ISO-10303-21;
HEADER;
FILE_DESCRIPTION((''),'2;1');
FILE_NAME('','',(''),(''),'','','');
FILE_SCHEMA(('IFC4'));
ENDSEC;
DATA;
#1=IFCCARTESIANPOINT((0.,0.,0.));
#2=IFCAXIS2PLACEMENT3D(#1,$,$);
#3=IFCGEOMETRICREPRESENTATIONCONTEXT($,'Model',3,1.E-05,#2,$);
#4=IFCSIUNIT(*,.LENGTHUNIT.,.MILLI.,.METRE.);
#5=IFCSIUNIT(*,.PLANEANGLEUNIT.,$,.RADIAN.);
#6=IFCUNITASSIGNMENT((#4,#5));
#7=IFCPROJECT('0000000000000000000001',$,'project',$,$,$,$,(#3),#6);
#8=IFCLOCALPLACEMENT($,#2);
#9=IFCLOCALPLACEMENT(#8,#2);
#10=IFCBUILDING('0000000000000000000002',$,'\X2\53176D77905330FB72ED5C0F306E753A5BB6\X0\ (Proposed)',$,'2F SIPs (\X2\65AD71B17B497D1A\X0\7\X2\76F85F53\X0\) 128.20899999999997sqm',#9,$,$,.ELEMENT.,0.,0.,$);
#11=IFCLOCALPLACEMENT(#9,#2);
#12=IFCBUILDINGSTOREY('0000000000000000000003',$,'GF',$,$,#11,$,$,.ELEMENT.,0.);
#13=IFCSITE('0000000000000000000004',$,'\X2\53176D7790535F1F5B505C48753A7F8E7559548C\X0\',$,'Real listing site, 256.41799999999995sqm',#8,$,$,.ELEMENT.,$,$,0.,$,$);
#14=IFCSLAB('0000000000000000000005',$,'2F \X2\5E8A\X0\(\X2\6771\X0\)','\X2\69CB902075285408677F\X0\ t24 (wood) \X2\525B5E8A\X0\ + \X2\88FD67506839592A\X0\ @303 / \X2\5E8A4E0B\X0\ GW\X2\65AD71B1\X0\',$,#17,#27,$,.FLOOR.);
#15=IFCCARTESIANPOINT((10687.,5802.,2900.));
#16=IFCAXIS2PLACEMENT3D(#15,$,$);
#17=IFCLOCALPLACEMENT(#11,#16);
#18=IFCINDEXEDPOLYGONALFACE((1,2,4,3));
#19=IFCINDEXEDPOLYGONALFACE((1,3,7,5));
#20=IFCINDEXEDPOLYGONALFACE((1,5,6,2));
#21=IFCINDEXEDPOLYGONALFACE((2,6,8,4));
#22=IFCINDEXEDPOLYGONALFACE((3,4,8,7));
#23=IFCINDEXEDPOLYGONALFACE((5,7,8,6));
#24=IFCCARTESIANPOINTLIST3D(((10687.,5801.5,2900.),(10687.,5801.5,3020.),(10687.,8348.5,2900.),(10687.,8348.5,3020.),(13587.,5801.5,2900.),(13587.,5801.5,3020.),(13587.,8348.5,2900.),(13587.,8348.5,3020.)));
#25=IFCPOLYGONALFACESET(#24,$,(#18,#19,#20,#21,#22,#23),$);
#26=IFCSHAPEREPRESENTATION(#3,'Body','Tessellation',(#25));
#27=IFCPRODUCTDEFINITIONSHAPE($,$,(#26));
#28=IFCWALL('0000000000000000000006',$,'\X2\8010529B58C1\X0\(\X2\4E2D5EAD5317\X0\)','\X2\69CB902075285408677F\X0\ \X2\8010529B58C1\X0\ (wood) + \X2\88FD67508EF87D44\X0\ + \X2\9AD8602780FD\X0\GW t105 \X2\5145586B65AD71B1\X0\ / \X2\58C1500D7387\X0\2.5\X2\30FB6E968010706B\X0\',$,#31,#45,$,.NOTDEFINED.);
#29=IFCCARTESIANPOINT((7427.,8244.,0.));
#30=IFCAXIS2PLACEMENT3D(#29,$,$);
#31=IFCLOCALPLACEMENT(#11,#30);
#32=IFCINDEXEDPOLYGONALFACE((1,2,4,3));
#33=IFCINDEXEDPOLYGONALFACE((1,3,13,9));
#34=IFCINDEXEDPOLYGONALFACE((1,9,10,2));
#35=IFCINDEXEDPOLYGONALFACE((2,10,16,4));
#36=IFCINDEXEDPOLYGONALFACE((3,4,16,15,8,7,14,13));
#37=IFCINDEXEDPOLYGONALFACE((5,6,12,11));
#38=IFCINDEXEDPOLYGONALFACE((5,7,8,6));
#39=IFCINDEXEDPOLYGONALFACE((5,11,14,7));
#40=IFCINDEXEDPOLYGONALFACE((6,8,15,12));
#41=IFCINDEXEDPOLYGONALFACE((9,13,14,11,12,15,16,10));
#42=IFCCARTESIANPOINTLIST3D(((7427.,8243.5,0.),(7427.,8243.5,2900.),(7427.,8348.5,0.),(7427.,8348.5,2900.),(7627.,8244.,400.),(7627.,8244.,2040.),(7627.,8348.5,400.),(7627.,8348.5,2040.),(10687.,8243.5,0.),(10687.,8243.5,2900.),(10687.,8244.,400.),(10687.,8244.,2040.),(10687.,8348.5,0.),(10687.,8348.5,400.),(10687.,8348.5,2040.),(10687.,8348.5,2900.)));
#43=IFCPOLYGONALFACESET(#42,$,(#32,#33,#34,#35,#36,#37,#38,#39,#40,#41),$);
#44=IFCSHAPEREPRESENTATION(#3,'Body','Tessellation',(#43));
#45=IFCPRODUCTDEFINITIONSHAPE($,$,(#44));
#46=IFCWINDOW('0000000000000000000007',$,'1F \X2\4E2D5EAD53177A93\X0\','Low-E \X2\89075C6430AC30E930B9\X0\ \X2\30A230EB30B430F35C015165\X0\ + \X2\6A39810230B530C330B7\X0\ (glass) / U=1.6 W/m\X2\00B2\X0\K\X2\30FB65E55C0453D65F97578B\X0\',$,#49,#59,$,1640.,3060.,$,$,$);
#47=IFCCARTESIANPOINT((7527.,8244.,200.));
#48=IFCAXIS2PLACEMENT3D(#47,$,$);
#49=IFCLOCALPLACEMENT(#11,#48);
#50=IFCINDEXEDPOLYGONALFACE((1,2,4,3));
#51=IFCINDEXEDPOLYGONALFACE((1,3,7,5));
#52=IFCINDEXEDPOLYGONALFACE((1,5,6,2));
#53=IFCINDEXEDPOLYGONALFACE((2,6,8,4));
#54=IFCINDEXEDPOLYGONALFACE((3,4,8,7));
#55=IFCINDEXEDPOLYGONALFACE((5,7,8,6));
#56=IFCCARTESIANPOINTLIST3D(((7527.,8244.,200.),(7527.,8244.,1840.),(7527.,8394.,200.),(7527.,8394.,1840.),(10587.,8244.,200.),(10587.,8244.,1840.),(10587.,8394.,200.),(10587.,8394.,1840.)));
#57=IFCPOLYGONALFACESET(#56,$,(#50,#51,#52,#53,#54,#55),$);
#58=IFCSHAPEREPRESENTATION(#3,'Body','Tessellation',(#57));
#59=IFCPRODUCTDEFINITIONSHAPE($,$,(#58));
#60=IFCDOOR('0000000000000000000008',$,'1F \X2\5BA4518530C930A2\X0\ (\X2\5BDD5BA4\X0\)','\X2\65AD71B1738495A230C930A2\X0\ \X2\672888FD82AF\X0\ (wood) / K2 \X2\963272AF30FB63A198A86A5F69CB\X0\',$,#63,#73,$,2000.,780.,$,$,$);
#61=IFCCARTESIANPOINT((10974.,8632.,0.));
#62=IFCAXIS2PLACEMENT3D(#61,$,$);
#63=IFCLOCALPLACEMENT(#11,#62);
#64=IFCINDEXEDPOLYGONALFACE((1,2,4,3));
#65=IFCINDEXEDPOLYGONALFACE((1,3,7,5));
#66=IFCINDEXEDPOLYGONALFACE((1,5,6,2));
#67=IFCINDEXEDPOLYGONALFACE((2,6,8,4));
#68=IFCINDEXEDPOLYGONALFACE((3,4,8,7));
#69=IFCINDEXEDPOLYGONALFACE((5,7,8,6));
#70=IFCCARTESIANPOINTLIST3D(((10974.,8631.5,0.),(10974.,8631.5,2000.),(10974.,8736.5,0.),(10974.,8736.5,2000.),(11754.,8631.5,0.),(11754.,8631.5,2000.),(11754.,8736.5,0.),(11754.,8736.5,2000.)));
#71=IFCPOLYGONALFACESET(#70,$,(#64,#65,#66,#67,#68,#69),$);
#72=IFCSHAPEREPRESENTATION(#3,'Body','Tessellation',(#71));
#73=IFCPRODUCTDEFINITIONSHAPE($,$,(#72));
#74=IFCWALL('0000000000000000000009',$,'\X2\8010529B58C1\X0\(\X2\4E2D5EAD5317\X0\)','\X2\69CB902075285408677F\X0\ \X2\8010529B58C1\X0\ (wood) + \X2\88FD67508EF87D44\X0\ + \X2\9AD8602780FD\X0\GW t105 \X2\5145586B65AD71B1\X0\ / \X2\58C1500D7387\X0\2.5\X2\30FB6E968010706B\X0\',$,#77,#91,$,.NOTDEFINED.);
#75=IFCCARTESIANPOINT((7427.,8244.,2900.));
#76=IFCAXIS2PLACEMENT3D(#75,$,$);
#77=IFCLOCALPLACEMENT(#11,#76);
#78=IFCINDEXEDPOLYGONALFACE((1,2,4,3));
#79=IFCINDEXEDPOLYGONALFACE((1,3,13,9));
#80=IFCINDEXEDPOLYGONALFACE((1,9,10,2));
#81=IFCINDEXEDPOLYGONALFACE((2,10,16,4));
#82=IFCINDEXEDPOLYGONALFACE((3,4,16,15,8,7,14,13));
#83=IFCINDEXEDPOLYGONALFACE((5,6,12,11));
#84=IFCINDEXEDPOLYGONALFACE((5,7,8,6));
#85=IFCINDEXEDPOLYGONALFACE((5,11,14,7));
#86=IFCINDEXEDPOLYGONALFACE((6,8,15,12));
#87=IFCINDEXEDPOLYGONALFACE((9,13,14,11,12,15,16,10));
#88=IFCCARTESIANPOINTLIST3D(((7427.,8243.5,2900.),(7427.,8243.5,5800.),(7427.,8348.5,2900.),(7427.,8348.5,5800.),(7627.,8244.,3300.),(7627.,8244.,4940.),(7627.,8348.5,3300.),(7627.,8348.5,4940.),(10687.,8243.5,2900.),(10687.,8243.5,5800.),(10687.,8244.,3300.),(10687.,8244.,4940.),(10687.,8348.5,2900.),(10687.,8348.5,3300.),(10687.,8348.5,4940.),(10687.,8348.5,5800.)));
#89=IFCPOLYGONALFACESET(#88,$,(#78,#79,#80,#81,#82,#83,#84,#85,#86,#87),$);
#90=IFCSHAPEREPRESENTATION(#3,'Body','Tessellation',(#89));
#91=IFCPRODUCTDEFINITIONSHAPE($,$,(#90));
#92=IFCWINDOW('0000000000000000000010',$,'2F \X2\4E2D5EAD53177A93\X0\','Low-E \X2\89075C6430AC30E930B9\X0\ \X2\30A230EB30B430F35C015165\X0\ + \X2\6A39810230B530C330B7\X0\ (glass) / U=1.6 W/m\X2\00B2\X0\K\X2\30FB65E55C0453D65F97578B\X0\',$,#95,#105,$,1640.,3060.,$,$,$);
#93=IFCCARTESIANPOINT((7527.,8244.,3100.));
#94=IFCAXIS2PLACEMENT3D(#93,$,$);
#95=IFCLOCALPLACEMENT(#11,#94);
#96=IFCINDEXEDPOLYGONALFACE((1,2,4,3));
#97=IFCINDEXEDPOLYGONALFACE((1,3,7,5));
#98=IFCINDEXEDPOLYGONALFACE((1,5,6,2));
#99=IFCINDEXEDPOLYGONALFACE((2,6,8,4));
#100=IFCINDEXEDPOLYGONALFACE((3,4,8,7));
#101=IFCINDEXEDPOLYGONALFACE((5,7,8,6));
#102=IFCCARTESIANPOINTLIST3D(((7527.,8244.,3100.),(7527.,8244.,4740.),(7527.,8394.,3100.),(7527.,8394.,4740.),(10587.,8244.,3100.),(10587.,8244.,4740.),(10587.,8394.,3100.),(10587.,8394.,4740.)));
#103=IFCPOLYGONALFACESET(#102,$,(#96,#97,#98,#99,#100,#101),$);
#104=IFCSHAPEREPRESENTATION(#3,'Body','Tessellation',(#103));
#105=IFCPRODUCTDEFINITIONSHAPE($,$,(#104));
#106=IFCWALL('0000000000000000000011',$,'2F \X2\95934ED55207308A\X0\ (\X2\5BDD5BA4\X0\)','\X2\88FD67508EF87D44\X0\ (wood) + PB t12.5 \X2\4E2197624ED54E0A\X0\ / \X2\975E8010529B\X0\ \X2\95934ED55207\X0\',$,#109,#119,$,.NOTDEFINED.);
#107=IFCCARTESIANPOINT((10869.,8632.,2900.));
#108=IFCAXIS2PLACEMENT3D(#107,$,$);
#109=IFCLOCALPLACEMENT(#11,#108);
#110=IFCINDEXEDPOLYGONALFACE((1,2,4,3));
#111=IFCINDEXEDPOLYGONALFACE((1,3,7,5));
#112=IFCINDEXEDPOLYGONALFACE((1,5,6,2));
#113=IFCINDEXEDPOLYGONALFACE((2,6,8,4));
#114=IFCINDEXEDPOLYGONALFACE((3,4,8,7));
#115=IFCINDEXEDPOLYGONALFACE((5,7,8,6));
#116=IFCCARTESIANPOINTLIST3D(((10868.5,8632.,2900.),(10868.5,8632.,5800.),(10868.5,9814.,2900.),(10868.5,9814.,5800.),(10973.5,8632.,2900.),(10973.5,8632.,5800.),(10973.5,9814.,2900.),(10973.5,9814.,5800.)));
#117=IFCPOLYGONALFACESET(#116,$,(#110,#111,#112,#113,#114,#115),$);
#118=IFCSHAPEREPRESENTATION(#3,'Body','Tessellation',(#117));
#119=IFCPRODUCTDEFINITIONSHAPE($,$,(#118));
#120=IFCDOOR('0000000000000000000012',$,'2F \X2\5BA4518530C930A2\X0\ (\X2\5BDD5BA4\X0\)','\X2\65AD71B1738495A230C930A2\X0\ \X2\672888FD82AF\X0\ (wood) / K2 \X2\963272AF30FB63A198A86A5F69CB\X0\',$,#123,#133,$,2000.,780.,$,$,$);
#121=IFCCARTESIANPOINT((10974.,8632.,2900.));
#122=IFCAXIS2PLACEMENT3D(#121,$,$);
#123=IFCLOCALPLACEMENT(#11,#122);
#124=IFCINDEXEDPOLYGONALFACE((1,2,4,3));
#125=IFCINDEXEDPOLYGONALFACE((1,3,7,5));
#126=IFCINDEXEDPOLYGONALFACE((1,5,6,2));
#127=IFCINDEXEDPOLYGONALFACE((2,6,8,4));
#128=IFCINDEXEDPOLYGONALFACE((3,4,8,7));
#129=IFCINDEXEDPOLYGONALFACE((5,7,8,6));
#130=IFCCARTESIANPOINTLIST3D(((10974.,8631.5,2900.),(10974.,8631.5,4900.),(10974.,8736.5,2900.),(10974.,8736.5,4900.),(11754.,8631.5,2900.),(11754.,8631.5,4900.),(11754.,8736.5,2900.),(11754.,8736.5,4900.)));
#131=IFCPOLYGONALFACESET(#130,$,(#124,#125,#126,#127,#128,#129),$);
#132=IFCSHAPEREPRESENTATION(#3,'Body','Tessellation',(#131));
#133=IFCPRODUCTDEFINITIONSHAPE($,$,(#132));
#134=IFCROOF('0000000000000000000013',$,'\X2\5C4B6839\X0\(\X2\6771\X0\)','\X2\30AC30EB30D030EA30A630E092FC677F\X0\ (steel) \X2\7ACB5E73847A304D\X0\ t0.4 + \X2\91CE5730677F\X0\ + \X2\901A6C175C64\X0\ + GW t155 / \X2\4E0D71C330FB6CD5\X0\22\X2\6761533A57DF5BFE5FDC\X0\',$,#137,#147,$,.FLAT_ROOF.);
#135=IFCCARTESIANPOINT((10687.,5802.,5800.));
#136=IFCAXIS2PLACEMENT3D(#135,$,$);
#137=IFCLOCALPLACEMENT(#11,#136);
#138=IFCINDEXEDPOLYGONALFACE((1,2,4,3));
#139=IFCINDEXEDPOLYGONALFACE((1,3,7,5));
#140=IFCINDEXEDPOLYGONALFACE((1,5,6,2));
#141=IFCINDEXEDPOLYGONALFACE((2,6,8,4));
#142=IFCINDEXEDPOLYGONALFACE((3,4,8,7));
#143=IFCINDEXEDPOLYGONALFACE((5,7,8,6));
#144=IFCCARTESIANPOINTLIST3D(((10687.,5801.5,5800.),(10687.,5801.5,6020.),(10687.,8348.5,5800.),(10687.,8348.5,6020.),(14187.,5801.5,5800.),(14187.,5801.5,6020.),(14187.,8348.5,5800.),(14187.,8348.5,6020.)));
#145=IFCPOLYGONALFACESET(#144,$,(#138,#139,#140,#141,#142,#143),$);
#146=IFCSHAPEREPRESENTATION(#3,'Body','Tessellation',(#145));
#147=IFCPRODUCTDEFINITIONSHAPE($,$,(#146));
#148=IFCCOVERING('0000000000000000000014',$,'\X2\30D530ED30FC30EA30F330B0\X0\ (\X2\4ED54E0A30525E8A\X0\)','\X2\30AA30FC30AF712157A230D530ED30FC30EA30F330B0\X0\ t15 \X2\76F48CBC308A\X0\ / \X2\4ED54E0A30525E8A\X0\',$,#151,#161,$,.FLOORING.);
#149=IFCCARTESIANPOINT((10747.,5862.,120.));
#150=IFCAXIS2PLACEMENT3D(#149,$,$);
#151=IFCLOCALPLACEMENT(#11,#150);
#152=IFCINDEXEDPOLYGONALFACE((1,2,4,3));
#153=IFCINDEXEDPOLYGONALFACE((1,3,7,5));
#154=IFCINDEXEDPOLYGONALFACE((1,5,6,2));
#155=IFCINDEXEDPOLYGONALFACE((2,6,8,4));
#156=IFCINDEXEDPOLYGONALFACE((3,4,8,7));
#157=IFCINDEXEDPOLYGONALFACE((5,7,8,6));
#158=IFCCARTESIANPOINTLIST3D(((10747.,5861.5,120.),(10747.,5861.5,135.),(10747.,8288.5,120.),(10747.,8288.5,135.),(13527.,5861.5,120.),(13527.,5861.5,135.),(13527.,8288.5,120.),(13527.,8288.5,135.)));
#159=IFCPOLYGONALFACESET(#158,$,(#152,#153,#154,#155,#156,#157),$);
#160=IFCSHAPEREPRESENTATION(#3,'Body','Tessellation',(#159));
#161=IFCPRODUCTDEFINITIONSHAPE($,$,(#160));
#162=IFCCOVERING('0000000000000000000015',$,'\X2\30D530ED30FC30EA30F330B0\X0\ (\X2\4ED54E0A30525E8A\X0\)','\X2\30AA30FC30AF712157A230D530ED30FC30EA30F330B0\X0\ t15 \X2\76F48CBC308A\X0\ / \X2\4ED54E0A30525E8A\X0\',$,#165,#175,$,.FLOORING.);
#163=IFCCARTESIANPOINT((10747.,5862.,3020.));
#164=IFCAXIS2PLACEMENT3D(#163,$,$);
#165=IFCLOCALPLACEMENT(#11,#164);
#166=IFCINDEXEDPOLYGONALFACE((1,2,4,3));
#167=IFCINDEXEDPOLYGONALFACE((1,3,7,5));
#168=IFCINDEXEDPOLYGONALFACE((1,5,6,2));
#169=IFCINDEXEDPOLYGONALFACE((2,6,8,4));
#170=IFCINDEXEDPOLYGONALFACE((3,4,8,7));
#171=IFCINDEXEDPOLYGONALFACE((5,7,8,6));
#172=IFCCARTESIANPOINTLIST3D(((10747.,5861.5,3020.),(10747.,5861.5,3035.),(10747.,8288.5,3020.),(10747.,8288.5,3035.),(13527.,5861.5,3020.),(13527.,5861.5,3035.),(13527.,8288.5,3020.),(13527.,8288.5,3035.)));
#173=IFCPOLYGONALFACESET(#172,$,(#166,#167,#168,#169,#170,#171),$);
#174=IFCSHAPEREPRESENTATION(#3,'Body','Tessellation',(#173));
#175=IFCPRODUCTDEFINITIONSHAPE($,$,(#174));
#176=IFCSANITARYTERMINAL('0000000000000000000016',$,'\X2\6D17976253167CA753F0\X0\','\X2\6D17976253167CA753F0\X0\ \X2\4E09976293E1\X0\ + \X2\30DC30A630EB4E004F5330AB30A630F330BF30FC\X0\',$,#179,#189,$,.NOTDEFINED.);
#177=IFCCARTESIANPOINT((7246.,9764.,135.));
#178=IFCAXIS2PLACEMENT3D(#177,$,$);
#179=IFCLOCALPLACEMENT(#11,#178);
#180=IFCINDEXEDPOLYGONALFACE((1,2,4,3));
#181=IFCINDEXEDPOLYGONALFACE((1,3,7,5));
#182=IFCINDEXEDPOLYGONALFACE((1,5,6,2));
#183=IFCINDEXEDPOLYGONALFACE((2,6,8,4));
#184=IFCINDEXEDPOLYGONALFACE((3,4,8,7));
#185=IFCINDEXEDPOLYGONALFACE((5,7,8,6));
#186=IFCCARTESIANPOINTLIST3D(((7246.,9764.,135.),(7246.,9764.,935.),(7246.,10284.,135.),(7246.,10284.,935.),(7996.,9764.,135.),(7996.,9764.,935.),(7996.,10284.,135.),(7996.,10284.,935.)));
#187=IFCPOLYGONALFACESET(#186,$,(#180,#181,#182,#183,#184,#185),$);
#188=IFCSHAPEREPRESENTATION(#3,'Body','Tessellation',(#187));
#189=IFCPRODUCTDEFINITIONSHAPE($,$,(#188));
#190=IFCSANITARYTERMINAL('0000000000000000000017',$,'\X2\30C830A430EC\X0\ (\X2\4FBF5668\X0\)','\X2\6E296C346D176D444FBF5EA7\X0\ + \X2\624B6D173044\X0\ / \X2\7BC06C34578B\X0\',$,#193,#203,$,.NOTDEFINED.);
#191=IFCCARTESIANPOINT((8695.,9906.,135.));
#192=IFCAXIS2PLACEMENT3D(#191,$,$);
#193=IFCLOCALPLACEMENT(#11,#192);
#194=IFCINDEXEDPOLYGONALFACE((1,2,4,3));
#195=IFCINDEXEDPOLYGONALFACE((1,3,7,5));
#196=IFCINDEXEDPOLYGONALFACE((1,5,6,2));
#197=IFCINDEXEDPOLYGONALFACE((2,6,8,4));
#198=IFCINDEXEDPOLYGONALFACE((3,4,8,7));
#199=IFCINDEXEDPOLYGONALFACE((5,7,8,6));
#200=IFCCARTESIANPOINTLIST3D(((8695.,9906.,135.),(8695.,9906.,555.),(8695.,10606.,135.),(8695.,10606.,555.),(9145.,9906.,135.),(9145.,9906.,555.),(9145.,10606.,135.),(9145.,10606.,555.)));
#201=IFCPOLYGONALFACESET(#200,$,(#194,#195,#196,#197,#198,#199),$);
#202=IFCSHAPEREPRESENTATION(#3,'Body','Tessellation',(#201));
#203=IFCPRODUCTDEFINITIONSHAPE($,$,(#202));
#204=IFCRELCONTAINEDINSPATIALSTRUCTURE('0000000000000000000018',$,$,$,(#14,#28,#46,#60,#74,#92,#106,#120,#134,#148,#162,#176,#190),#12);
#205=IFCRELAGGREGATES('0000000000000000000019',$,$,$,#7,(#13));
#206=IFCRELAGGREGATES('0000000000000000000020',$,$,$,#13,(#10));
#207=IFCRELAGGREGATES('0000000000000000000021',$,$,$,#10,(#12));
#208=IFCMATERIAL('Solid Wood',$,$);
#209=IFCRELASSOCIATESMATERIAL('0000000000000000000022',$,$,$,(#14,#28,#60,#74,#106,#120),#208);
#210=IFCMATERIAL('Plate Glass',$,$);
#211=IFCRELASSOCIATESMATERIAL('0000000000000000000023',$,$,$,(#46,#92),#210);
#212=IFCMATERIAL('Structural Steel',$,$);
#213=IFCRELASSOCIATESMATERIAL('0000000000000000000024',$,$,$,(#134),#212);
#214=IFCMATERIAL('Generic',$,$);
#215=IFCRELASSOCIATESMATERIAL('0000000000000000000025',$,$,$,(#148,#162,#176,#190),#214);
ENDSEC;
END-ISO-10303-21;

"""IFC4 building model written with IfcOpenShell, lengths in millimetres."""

from ifc_helpers import new_model, si_unit, frame, frame_2d, origin, place, context, project, spatial, rectangle, extrude, material, element, fill, save


model = new_model("IFC4")

# Units and contexts
model_context = context("Model", 3, precision=1e-05, world=origin())
ifc_project = project(units=[si_unit("LENGTHUNIT", "METRE", prefix="MILLI"), si_unit("PLANEANGLEUNIT", "RADIAN")], contexts=[model_context])

# Site, building, storey
site_placement = place(None, origin())
site = spatial("IfcSite", under=ifc_project, at=site_placement, Name="北海道弟子屈町美留和", ObjectType="Real listing site, 256.41799999999995sqm", CompositionType="ELEMENT", RefElevation=0.0)
building_placement = place(site_placement, origin())
building = spatial("IfcBuilding", under=site, at=building_placement, Name="北海道・狭小の町家 (Proposed)", ObjectType="2F SIPs (断熱等級7相当) 128.20899999999997sqm", CompositionType="ELEMENT", ElevationOfRefHeight=0.0, ElevationOfTerrain=0.0)
storey_placement = place(building_placement, origin())
storey = spatial("IfcBuildingStorey", under=building, at=storey_placement, Name="GF", CompositionType="ELEMENT", Elevation=0.0)

# Slab
ifc_material_1 = material(Name="Solid Wood")
slab_1_placement = place(storey_placement, frame((10687.0, 5802.0, 2900.0)))
element("IfcSlab", 1, at=slab_1_placement, inside=storey, material=ifc_material_1, Name="2F 床(東)", Description="構造用合板 t24 (wood) 剛床 + 製材根太 @303 / 床下 GW断熱", PredefinedType="FLOOR", context=model_context, shape_type="SweptSolid", body=[
    extrude(rectangle(XDim=2900.0, YDim=2547.0, at=frame_2d((1450.0, 1273.0))), frame((10687.0, 5802.0, 2900.0)), (0.0, 0.0, 1.0), 120.0),
])

# Wall, opening, window
wall_1_placement = place(storey_placement, frame((7427.0, 8244.0, 0.0)))
wall_1 = element("IfcWall", 2, at=wall_1_placement, inside=storey, material=ifc_material_1, Name="耐力壁(中庭北)", Description="構造用合板 耐力壁 (wood) + 製材軸組 + 高性能GW t105 充填断熱 / 壁倍率2.5・準耐火", PredefinedType="NOTDEFINED", context=model_context, shape_type="SweptSolid", body=[
    extrude(rectangle(XDim=3260.0, YDim=105.0, at=frame_2d((1630.0, 52.0))), frame((7427.0, 8244.0, 0.0)), (0.0, 0.0, 1.0), 2900.0),
])
opening_1_placement = place(storey_placement, frame((7527.0, 8244.0, 200.0)))
opening_1 = element("IfcOpeningElement", 3, at=opening_1_placement, cuts=wall_1, PredefinedType="NOTDEFINED", context=model_context, shape_type="SweptSolid", body=[
    extrude(rectangle(XDim=3060.0, YDim=150.0, at=frame_2d((1530.0, 75.0))), frame((7527.0, 8244.0, 200.0)), (0.0, 0.0, 1.0), 1640.0),
])
ifc_material_2 = material(Name="Plate Glass")
window_1_placement = place(storey_placement, frame((7527.0, 8244.0, 200.0)))
window_1 = element("IfcWindow", 4, at=window_1_placement, inside=storey, material=ifc_material_2, Name="1F 中庭北窓", Description="Low-E 複層ガラス アルゴン封入 + 樹脂サッシ (glass) / U=1.6 W/m²K・日射取得型", OverallHeight=1640.0, OverallWidth=3060.0, context=model_context, shape_type="SweptSolid", body=[
    extrude(rectangle(XDim=3060.0, YDim=150.0, at=frame_2d((1530.0, 75.0))), frame((7527.0, 8244.0, 200.0)), (0.0, 0.0, 1.0), 1640.0),
])
fill(opening_1, window_1)

# Door
door_1_placement = place(storey_placement, frame((10974.0, 8632.0, 0.0)))
element("IfcDoor", 5, at=door_1_placement, inside=storey, material=ifc_material_1, Name="1F 室内ドア (寝室)", Description="断熱玄関ドア 木製芯 (wood) / K2 防犯・採風機構", OverallHeight=2000.0, OverallWidth=780.0, context=model_context, shape_type="SweptSolid", body=[
    extrude(rectangle(XDim=780.0, YDim=105.0, at=frame_2d((390.0, 52.0))), frame((10974.0, 8632.0, 0.0)), (0.0, 0.0, 1.0), 2000.0),
])

# Wall, opening, window
wall_2_placement = place(storey_placement, frame((7427.0, 8244.0, 2900.0)))
wall_2 = element("IfcWall", 6, at=wall_2_placement, inside=storey, material=ifc_material_1, Name="耐力壁(中庭北)", Description="構造用合板 耐力壁 (wood) + 製材軸組 + 高性能GW t105 充填断熱 / 壁倍率2.5・準耐火", PredefinedType="NOTDEFINED", context=model_context, shape_type="SweptSolid", body=[
    extrude(rectangle(XDim=3260.0, YDim=105.0, at=frame_2d((1630.0, 52.0))), frame((7427.0, 8244.0, 2900.0)), (0.0, 0.0, 1.0), 2900.0),
])
opening_2_placement = place(storey_placement, frame((7527.0, 8244.0, 3100.0)))
opening_2 = element("IfcOpeningElement", 7, at=opening_2_placement, cuts=wall_2, PredefinedType="NOTDEFINED", context=model_context, shape_type="SweptSolid", body=[
    extrude(rectangle(XDim=3060.0, YDim=150.0, at=frame_2d((1530.0, 75.0))), frame((7527.0, 8244.0, 3100.0)), (0.0, 0.0, 1.0), 1640.0),
])
window_2_placement = place(storey_placement, frame((7527.0, 8244.0, 3100.0)))
window_2 = element("IfcWindow", 8, at=window_2_placement, inside=storey, material=ifc_material_2, Name="2F 中庭北窓", Description="Low-E 複層ガラス アルゴン封入 + 樹脂サッシ (glass) / U=1.6 W/m²K・日射取得型", OverallHeight=1640.0, OverallWidth=3060.0, context=model_context, shape_type="SweptSolid", body=[
    extrude(rectangle(XDim=3060.0, YDim=150.0, at=frame_2d((1530.0, 75.0))), frame((7527.0, 8244.0, 3100.0)), (0.0, 0.0, 1.0), 1640.0),
])
fill(opening_2, window_2)

# Wall
wall_3_placement = place(storey_placement, frame((10869.0, 8632.0, 2900.0)))
element("IfcWall", 9, at=wall_3_placement, inside=storey, material=ifc_material_1, Name="2F 間仕切り (寝室)", Description="製材軸組 (wood) + PB t12.5 両面仕上 / 非耐力 間仕切", PredefinedType="NOTDEFINED", context=model_context, shape_type="SweptSolid", body=[
    extrude(rectangle(XDim=105.0, YDim=1182.0, at=frame_2d((52.0, 591.0))), frame((10869.0, 8632.0, 2900.0)), (0.0, 0.0, 1.0), 2900.0),
])

# Door
door_2_placement = place(storey_placement, frame((10974.0, 8632.0, 2900.0)))
element("IfcDoor", 10, at=door_2_placement, inside=storey, material=ifc_material_1, Name="2F 室内ドア (寝室)", Description="断熱玄関ドア 木製芯 (wood) / K2 防犯・採風機構", OverallHeight=2000.0, OverallWidth=780.0, context=model_context, shape_type="SweptSolid", body=[
    extrude(rectangle(XDim=780.0, YDim=105.0, at=frame_2d((390.0, 52.0))), frame((10974.0, 8632.0, 2900.0)), (0.0, 0.0, 1.0), 2000.0),
])

# Roof
ifc_material_3 = material(Name="Structural Steel")
for number, where, name in (
    (11, (10687.0, 5802.0, 5800.0), "屋根(東)"),
):
    element("IfcRoof", number, at=place(storey_placement, frame(where)), inside=storey, material=ifc_material_3, Name=name, Description="ガルバリウム鋼板 (steel) 立平葺き t0.4 + 野地板 + 通気層 + GW t155 / 不燃・法22条区域対応", PredefinedType="FLAT_ROOF", context=model_context, shape_type="SweptSolid", body=[
        extrude(rectangle(XDim=3500.0, YDim=2547.0, at=frame_2d((1750.0, 1273.0))), frame((10687.0, 5802.0, 5800.0)), (0.0, 0.0, 1.0), 220.0),
    ])

# Coverings
ifc_material_4 = material(Name="Generic")
covering_1_placement = place(storey_placement, frame((10747.0, 5862.0, 120.0)))
element("IfcCovering", 12, at=covering_1_placement, inside=storey, material=ifc_material_4, Name="フローリング (仕上げ床)", Description="オーク無垢フローリング t15 直貼り / 仕上げ床", PredefinedType="FLOORING", context=model_context, shape_type="SweptSolid", body=[
    extrude(rectangle(XDim=2780.0, YDim=2427.0, at=frame_2d((1390.0, 1213.0))), frame((10747.0, 5862.0, 120.0)), (0.0, 0.0, 1.0), 15.0),
])
covering_2_placement = place(storey_placement, frame((10747.0, 5862.0, 3020.0)))
element("IfcCovering", 13, at=covering_2_placement, inside=storey, material=ifc_material_4, Name="フローリング (仕上げ床)", Description="オーク無垢フローリング t15 直貼り / 仕上げ床", PredefinedType="FLOORING", context=model_context, shape_type="SweptSolid", body=[
    extrude(rectangle(XDim=2780.0, YDim=2427.0, at=frame_2d((1390.0, 1213.0))), frame((10747.0, 5862.0, 3020.0)), (0.0, 0.0, 1.0), 15.0),
])

# Sanitary terminals
sanitary_terminal_1_placement = place(storey_placement, frame((7246.0, 9764.0, 135.0)))
element("IfcSanitaryTerminal", 14, at=sanitary_terminal_1_placement, inside=storey, material=ifc_material_4, Name="洗面化粧台", Description="洗面化粧台 三面鏡 + ボウル一体カウンター", PredefinedType="NOTDEFINED", context=model_context, shape_type="SweptSolid", body=[
    extrude(rectangle(XDim=750.0, YDim=520.0, at=frame_2d((375.0, 260.0))), frame((7246.0, 9764.0, 135.0)), (0.0, 0.0, 1.0), 800.0),
])
sanitary_terminal_2_placement = place(storey_placement, frame((8695.0, 9906.0, 135.0)))
element("IfcSanitaryTerminal", 15, at=sanitary_terminal_2_placement, inside=storey, material=ifc_material_4, Name="トイレ (便器)", Description="温水洗浄便座 + 手洗い / 節水型", PredefinedType="NOTDEFINED", context=model_context, shape_type="SweptSolid", body=[
    extrude(rectangle(XDim=450.0, YDim=700.0, at=frame_2d((225.0, 350.0))), frame((8695.0, 9906.0, 135.0)), (0.0, 0.0, 1.0), 420.0),
])

save(model, "model.ifc")
